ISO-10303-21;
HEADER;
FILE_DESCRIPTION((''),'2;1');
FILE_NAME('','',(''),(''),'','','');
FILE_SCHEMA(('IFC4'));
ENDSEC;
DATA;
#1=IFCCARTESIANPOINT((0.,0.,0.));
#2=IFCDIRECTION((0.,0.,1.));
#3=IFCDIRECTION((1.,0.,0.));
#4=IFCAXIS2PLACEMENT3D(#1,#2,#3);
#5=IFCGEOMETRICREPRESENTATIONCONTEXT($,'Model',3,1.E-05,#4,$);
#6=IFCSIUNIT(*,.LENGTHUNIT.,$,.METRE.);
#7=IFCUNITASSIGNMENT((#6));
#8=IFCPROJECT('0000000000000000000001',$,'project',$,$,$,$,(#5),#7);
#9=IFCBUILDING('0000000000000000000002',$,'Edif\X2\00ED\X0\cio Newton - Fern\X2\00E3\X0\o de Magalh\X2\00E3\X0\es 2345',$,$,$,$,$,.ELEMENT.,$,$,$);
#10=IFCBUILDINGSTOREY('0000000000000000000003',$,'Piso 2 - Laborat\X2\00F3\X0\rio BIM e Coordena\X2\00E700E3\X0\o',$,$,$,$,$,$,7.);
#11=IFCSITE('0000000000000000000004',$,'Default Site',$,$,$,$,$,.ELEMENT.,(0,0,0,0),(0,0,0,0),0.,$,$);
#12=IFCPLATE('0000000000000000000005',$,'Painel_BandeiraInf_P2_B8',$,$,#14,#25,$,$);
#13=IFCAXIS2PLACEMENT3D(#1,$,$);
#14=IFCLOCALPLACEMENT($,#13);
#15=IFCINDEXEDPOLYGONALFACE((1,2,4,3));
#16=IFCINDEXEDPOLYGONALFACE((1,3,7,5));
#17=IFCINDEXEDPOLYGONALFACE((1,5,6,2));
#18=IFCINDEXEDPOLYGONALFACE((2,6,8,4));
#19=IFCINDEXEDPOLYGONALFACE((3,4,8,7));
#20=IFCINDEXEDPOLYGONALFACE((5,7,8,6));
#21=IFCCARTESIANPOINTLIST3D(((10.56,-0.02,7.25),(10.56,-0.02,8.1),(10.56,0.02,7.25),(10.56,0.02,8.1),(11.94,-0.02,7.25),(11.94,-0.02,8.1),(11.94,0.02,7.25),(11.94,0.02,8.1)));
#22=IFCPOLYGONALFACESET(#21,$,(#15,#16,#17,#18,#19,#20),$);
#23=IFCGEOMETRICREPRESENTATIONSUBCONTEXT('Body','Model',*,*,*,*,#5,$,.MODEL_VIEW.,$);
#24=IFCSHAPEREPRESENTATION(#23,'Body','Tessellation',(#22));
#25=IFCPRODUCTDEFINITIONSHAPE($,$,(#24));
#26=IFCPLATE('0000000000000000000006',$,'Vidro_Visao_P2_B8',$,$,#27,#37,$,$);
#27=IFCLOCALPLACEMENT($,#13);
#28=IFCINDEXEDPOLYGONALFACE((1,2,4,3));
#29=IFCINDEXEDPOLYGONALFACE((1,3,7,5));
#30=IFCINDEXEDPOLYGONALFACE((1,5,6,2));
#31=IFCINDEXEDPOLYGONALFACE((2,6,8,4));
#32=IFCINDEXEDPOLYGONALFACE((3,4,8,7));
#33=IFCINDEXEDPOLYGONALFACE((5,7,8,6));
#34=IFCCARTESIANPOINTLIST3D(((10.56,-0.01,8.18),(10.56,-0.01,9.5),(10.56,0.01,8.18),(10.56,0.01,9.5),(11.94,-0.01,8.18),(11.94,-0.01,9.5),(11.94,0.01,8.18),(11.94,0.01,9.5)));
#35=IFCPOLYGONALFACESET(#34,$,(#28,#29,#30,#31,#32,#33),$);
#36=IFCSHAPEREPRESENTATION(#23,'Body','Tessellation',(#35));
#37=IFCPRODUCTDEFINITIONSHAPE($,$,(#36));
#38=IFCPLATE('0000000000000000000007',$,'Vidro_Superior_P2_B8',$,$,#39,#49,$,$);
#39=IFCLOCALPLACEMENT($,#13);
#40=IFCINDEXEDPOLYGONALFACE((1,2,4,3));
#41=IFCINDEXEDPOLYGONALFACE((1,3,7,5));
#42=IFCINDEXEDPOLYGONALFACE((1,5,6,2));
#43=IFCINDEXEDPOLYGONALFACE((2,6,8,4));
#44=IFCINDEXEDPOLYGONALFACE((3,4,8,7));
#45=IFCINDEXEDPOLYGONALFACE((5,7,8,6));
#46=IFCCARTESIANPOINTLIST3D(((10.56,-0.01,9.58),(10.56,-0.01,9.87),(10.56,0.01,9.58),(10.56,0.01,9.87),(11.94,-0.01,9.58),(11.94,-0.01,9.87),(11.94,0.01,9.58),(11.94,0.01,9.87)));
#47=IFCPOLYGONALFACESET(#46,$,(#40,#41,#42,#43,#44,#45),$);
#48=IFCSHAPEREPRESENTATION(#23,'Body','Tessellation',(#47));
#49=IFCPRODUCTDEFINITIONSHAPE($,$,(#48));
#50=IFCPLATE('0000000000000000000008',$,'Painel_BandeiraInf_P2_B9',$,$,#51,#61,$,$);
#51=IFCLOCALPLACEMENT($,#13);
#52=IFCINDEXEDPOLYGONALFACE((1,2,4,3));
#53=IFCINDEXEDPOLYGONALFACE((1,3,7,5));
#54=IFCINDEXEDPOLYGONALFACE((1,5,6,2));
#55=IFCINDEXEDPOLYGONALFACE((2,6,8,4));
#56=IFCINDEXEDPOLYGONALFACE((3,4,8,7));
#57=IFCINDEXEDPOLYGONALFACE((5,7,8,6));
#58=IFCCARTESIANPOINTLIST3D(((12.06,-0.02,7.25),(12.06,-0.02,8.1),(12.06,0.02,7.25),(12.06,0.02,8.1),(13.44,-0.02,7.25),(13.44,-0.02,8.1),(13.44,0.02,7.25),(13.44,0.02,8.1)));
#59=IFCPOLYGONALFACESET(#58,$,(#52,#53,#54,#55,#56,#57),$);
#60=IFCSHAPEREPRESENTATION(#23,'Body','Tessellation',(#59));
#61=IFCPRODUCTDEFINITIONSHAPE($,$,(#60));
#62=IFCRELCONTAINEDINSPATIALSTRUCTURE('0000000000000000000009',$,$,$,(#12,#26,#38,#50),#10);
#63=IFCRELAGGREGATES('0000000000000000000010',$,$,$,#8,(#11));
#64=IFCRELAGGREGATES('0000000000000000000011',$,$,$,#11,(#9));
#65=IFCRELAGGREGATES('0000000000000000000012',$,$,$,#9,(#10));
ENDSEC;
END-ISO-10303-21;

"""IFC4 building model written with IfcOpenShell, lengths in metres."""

from ifc_helpers import new_model, si_unit, frame, frame_2d, origin_with_axes, place, context, subcontext, project, spatial, rectangle, extrude, element, save


model = new_model("IFC4")

# Units and contexts
model_context = context("Model", 3, precision=1e-05, world=origin_with_axes())
body_context = subcontext(model_context, "Body", "Model", "MODEL_VIEW")
ifc_project = project(units=[si_unit("LENGTHUNIT", "METRE")], contexts=[model_context])

# Site, building, storey
site = spatial("IfcSite", under=ifc_project, Name="Default Site", CompositionType="ELEMENT", RefLatitude=(0, 0, 0, 0), RefLongitude=(0, 0, 0, 0), RefElevation=0.0)
building = spatial("IfcBuilding", under=site, Name="Edifício Newton - Fernão de Magalhães 2345", CompositionType="ELEMENT")
storey = spatial("IfcBuildingStorey", under=building, Name="Piso 2 - Laboratório BIM e Coordenação", Elevation=7.0)

# Plates
plate_1_placement = place(None, frame((10.56, -0.02, 7.25), z_axis=(0.0, 0.0, 1.0), x_axis=(1.0, 0.0, 0.0)))
element("IfcPlate", 1, at=plate_1_placement, inside=storey, Name="Painel_BandeiraInf_P2_B8", context=body_context, shape_type="SweptSolid", body=[
    extrude(rectangle(XDim=1.38, YDim=0.04, at=frame_2d((0.69, 0.02))), origin_with_axes(), (0.0, 0.0, 1.0), 0.85),
])
plate_2_placement = place(None, frame((10.56, -0.01, 8.18), z_axis=(0.0, 0.0, 1.0), x_axis=(1.0, 0.0, 0.0)))
element("IfcPlate", 2, at=plate_2_placement, inside=storey, Name="Vidro_Visao_P2_B8", context=body_context, shape_type="SweptSolid", body=[
    extrude(rectangle(XDim=1.38, YDim=0.02, at=frame_2d((0.69, 0.01))), origin_with_axes(), (0.0, 0.0, 1.0), 1.32),
])
plate_3_placement = place(None, frame((10.56, -0.01, 9.58), z_axis=(0.0, 0.0, 1.0), x_axis=(1.0, 0.0, 0.0)))
element("IfcPlate", 3, at=plate_3_placement, inside=storey, Name="Vidro_Superior_P2_B8", context=body_context, shape_type="SweptSolid", body=[
    extrude(rectangle(XDim=1.38, YDim=0.02, at=frame_2d((0.69, 0.01))), origin_with_axes(), (0.0, 0.0, 1.0), 0.29),
])
plate_4_placement = place(None, frame((12.06, -0.02, 7.25), z_axis=(0.0, 0.0, 1.0), x_axis=(1.0, 0.0, 0.0)))
element("IfcPlate", 4, at=plate_4_placement, inside=storey, Name="Painel_BandeiraInf_P2_B9", context=body_context, shape_type="SweptSolid", body=[
    extrude(rectangle(XDim=1.38, YDim=0.04, at=frame_2d((0.69, 0.02))), origin_with_axes(), (0.0, 0.0, 1.0), 0.85),
])

save(model, "model.ifc")
